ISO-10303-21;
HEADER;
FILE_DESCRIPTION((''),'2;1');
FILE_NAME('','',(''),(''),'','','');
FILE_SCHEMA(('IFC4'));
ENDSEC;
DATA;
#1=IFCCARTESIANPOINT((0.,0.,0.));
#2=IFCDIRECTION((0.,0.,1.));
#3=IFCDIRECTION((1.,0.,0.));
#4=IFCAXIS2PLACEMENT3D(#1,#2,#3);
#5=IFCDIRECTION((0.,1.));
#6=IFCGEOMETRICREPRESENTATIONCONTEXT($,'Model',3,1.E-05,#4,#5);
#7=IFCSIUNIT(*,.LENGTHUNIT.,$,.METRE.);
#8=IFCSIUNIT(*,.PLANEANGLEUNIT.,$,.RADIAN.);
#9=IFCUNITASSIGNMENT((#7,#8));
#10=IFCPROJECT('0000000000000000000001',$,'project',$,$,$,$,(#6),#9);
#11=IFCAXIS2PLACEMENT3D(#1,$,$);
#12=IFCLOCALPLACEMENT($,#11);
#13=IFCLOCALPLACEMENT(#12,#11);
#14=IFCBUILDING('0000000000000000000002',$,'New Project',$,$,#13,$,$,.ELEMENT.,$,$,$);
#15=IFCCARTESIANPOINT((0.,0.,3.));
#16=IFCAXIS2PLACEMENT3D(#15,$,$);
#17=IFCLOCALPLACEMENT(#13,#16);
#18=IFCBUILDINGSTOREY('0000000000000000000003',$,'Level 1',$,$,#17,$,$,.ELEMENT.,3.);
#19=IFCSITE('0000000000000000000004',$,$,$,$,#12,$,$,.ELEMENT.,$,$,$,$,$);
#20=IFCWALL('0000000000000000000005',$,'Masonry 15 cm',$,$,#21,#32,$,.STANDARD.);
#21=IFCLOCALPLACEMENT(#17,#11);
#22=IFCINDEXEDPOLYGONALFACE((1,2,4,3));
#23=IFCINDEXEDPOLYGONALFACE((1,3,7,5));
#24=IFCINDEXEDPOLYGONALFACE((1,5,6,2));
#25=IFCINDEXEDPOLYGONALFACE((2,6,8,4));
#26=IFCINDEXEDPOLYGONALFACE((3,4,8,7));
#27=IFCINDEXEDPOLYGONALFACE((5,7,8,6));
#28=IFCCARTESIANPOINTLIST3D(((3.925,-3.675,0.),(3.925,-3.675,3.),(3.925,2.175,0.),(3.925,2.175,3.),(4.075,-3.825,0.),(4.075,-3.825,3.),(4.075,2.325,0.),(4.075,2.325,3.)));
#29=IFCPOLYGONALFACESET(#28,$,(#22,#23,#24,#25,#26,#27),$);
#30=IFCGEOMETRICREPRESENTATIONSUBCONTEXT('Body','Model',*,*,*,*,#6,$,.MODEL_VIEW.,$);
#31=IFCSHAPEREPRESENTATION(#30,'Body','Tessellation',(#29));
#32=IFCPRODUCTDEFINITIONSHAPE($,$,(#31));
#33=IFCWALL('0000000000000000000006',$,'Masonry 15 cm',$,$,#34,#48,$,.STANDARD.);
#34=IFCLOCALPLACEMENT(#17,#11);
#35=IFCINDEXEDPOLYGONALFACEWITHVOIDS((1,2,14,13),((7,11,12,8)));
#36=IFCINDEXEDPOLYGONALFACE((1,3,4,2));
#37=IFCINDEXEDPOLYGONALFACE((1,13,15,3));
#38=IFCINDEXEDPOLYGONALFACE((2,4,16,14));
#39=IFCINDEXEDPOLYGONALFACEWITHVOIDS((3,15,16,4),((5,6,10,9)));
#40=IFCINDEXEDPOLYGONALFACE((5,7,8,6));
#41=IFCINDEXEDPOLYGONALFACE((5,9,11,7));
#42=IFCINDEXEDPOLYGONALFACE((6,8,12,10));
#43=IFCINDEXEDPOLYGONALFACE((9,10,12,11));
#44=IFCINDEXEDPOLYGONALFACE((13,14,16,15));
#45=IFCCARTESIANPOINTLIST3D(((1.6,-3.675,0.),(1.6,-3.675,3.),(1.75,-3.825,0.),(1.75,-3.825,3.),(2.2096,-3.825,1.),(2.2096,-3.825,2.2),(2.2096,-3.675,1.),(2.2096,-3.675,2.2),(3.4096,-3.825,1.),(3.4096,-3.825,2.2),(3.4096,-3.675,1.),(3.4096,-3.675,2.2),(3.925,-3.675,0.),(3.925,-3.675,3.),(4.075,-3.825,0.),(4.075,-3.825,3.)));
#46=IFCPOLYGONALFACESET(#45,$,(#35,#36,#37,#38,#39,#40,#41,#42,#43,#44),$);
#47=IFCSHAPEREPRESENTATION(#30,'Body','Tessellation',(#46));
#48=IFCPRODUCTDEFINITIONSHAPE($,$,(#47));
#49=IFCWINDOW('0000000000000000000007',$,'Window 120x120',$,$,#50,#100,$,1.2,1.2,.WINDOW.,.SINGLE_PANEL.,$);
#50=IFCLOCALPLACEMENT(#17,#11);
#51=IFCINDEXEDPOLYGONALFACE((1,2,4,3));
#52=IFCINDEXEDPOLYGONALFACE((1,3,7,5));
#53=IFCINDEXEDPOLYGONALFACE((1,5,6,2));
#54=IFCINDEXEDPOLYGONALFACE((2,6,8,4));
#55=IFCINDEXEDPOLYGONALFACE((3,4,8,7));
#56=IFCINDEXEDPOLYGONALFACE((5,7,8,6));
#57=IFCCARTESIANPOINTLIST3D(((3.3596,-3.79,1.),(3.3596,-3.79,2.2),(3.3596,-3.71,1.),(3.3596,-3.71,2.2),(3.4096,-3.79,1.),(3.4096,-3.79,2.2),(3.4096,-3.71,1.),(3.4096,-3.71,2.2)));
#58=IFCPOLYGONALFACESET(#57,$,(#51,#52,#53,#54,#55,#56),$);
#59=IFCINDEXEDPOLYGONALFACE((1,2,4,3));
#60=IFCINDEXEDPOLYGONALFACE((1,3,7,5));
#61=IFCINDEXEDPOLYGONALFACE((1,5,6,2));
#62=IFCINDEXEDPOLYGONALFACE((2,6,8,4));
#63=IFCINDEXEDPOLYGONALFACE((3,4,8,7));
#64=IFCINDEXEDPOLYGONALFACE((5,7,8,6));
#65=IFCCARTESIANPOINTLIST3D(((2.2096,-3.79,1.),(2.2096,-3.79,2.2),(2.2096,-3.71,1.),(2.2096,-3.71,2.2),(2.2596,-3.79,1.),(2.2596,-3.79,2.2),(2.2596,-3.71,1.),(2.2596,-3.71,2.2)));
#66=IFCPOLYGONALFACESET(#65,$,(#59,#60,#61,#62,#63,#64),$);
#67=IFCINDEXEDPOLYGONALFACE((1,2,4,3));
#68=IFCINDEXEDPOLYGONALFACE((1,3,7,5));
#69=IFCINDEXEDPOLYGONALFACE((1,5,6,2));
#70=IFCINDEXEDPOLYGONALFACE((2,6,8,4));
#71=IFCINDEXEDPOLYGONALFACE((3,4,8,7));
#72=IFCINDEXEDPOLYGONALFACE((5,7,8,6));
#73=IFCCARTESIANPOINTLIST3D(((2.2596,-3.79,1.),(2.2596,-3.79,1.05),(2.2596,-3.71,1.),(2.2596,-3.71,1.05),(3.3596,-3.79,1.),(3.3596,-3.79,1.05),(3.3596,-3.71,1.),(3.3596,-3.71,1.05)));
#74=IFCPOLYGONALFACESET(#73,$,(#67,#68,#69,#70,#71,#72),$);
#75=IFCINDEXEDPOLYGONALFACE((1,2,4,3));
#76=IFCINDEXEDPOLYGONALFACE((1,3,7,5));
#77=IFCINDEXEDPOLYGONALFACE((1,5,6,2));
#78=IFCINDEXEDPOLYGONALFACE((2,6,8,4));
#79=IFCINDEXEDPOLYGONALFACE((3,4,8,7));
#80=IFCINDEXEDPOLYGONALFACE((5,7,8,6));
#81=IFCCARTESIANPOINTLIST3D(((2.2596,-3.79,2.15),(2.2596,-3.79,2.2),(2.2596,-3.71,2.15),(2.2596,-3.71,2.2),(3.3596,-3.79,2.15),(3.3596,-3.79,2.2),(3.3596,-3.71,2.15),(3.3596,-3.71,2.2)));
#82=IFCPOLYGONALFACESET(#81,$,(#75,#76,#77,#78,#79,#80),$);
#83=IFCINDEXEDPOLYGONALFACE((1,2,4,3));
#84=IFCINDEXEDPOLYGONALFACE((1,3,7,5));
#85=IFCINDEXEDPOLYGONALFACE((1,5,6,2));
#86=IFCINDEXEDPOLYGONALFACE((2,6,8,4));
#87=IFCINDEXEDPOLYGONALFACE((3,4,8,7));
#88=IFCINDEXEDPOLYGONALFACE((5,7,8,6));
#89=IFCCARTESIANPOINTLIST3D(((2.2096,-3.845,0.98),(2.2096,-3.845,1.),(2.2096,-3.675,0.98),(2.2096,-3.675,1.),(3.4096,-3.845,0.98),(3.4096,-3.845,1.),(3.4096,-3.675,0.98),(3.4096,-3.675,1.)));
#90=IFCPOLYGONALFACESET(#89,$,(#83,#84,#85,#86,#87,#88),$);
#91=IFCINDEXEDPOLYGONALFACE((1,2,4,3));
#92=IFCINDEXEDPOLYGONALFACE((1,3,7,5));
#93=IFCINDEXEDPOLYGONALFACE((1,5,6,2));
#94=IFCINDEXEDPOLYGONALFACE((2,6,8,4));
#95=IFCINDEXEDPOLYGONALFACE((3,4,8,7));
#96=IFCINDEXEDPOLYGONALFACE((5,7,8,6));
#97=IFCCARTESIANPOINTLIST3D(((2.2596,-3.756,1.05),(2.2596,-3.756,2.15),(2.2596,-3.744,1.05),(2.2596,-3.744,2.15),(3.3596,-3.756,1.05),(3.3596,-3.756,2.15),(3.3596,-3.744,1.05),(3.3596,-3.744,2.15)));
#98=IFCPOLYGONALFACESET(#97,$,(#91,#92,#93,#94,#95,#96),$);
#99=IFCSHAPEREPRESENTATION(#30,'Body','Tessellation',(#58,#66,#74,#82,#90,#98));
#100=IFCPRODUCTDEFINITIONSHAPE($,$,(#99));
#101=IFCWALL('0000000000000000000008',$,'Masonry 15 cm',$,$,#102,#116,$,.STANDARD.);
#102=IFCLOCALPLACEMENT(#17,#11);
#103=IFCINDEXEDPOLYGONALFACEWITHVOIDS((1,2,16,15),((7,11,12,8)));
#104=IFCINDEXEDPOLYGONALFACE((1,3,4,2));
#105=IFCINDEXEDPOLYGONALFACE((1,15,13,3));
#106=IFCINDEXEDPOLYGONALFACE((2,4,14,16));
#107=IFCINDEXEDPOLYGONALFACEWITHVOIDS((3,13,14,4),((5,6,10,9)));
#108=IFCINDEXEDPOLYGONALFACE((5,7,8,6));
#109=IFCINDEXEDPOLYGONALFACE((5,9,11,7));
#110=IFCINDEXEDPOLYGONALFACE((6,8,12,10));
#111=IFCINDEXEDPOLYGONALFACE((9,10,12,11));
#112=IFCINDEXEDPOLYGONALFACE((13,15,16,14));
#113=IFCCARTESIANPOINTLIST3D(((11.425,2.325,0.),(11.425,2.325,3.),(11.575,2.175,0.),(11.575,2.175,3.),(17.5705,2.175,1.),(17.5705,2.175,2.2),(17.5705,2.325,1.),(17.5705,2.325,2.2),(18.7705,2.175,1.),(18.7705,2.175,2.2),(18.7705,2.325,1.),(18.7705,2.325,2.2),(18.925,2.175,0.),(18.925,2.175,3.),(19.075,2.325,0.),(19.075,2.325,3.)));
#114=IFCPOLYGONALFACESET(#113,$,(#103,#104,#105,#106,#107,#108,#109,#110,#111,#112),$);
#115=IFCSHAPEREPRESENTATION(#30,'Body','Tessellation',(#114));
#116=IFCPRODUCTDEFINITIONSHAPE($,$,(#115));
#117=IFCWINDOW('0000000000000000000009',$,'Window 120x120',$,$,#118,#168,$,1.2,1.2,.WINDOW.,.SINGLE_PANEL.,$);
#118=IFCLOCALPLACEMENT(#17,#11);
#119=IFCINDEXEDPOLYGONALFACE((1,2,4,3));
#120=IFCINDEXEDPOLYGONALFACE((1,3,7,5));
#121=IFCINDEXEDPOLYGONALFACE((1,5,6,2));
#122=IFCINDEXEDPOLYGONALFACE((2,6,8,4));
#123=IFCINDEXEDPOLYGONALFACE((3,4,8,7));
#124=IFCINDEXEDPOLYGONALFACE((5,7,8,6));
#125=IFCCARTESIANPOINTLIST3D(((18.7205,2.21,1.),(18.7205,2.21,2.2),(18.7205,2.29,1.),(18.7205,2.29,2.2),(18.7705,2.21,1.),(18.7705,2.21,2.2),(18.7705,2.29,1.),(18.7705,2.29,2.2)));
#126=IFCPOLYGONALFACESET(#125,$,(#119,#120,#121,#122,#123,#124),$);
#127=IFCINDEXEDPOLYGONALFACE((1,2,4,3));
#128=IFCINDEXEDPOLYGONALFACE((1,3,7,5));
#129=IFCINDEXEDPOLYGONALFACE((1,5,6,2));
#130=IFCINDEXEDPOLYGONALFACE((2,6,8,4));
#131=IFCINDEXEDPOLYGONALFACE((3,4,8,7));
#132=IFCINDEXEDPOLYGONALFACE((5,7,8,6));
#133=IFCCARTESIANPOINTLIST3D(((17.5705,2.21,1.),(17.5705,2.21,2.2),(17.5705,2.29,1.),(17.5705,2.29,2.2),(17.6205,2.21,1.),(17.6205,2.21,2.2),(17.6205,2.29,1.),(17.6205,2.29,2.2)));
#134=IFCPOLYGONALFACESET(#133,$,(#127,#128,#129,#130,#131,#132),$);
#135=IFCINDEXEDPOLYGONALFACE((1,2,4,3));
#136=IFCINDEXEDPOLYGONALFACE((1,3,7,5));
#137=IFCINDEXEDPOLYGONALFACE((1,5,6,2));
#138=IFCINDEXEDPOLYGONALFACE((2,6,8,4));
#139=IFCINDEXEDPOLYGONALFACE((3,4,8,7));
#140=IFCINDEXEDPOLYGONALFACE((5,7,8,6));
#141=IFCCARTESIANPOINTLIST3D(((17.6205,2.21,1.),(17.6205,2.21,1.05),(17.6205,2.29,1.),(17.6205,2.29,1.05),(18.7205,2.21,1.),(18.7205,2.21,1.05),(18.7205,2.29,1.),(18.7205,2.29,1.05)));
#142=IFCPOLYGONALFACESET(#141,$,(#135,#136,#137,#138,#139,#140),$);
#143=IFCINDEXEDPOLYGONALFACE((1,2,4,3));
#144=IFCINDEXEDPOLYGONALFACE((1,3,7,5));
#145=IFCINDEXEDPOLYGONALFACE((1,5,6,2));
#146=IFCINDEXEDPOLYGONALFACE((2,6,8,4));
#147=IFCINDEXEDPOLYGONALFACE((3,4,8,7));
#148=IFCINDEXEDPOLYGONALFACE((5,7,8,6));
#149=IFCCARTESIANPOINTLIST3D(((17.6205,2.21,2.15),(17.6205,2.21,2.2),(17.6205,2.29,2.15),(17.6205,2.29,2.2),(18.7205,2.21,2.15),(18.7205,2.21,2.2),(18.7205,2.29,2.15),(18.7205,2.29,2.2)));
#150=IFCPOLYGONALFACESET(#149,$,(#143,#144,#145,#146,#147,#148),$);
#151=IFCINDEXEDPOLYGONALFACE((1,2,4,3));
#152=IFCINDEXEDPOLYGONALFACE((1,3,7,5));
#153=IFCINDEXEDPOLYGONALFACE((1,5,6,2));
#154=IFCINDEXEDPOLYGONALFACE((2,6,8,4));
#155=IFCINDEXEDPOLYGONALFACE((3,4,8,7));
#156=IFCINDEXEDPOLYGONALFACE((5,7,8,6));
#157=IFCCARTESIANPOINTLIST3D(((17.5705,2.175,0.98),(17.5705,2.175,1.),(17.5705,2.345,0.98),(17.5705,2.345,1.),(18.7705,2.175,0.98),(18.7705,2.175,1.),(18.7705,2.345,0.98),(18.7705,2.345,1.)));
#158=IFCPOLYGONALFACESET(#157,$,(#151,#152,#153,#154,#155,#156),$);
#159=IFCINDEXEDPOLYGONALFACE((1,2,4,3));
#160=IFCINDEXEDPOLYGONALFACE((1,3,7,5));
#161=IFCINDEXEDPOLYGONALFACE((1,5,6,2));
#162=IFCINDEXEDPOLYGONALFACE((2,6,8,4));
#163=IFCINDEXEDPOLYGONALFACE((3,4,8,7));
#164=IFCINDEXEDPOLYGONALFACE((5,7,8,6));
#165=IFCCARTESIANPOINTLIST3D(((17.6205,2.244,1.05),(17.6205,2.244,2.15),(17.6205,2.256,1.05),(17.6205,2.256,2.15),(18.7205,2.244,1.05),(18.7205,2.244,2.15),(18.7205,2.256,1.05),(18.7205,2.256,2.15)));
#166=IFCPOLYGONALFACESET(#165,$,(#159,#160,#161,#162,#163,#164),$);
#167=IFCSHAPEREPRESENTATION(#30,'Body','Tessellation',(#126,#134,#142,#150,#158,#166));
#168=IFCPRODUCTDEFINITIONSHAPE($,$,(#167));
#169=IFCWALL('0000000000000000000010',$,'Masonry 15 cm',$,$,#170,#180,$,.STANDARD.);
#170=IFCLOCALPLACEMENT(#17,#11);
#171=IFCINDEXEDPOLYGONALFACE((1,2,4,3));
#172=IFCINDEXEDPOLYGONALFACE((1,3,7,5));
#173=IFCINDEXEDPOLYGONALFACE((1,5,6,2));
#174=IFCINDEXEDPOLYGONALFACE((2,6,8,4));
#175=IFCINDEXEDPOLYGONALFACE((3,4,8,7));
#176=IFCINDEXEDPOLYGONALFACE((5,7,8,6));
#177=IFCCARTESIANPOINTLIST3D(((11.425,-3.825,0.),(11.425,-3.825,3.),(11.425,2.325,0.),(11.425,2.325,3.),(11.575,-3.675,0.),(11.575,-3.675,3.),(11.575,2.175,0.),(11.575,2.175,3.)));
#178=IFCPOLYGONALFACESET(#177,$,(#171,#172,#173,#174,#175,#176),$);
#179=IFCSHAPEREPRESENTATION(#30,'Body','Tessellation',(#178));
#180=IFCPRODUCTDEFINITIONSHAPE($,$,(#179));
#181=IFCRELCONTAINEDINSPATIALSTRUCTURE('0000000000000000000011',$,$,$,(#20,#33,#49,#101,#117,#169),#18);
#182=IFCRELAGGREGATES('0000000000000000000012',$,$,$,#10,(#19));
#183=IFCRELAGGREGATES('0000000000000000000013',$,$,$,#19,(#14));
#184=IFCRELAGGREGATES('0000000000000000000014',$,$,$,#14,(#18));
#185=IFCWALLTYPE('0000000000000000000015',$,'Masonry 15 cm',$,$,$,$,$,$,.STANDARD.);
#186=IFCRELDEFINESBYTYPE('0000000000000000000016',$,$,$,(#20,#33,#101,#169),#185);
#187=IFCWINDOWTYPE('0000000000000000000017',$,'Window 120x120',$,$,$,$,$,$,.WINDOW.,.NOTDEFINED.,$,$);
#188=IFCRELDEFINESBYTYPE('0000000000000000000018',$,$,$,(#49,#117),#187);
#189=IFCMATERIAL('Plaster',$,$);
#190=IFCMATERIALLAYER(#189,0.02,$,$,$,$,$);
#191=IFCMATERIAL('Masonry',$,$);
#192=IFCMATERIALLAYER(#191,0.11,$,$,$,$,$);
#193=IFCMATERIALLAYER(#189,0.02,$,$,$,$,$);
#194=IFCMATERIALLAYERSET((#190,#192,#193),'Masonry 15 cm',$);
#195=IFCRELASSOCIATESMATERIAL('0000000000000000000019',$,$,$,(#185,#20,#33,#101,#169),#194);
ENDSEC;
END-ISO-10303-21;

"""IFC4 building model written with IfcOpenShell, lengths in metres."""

from ifc_helpers import new_model, si_unit, direction, frame, frame_2d, origin, origin_with_axes, place, context, subcontext, project, spatial, polyline, rectangle, outline, extrude, material, layer, layer_set, layer_usage, type_object, element, fill, save


model = new_model("IFC4")

# Units and contexts
model_context = context("Model", 3, precision=1e-05, world=origin_with_axes(), true_north=direction((0.0, 1.0)))
body_context = subcontext(model_context, "Body", "Model", "MODEL_VIEW")
ifc_project = project(units=[si_unit("LENGTHUNIT", "METRE"), si_unit("PLANEANGLEUNIT", "RADIAN")], contexts=[model_context])

# Site, building, storey
site_placement = place(None, origin())
site = spatial("IfcSite", under=ifc_project, at=site_placement, CompositionType="ELEMENT")
building_placement = place(site_placement, origin())
building = spatial("IfcBuilding", under=site, at=building_placement, Name="New Project", CompositionType="ELEMENT")
storey_placement = place(building_placement, frame((0.0, 0.0, 3.0)))
storey = spatial("IfcBuildingStorey", under=building, at=storey_placement, Name="Level 1", CompositionType="ELEMENT", Elevation=3.0)

# Wall
ifc_material_1 = material(Name="Plaster")
ifc_layer_1 = layer(ifc_material_1, 0.02)
ifc_material_2 = material(Name="Masonry")
ifc_layer_2 = layer(ifc_material_2, 0.11)
ifc_layer_3 = layer(ifc_material_1, 0.02)
ifc_layer_set_1 = layer_set([ifc_layer_1, ifc_layer_2, ifc_layer_3], Name="Masonry 15 cm")
ifc_layer_usage_1 = layer_usage(ifc_layer_set_1, "AXIS2", "NEGATIVE", 0.075)
wall_type_1 = type_object("IfcWallType", Name="Masonry 15 cm", PredefinedType="STANDARD", material=ifc_layer_set_1)
wall_1_placement = place(storey_placement, frame((4.0, 2.25, 0.0), z_axis=(0.0, 0.0, 1.0), x_axis=(0.0, -1.0, 0.0)))
element("IfcWall", 1, at=wall_1_placement, inside=storey, type_object=wall_type_1, material=ifc_layer_usage_1, Name="Masonry 15 cm", PredefinedType="STANDARD", context=body_context, shape_type="SweptSolid", body=[
    extrude(outline(polyline([(0.075, -0.075), (5.925, -0.075), (6.075, 0.075), (-0.075, 0.075), (0.075, -0.075)])), origin(), (0.0, 0.0, 1.0), 3.0),
])

# Walls, openings, windows
wall_2_placement = place(storey_placement, frame((4.0, -3.75, 0.0), z_axis=(0.0, 0.0, 1.0), x_axis=(-1.0, 0.0, 0.0)))
wall_2 = element("IfcWall", 2, at=wall_2_placement, inside=storey, type_object=wall_type_1, material=ifc_layer_usage_1, Name="Masonry 15 cm", PredefinedType="STANDARD", context=body_context, shape_type="SweptSolid", body=[
    extrude(outline(polyline([(0.075, -0.075), (2.4, -0.075), (2.25, 0.075), (-0.075, 0.075), (0.075, -0.075)])), origin(), (0.0, 0.0, 1.0), 3.0),
])
opening_1_placement = place(wall_2_placement, frame((0.5904, 0.0, 1.0)))
opening_1 = element("IfcOpeningElement", 3, at=opening_1_placement, cuts=wall_2, PredefinedType="OPENING", context=body_context, shape_type="SweptSolid", body=[
    extrude(rectangle(XDim=1.2, YDim=0.25, at=frame_2d((0.6, 0.0))), origin(), (0.0, 0.0, 1.0), 1.2),
])
window_type_1 = type_object("IfcWindowType", Name="Window 120x120", PartitioningType="NOTDEFINED", PredefinedType="WINDOW")
window_1_placement = place(opening_1_placement, origin())
window_1 = element("IfcWindow", 4, at=window_1_placement, inside=storey, type_object=window_type_1, Name="Window 120x120", OverallHeight=1.2, OverallWidth=1.2, PartitioningType="SINGLE_PANEL", PredefinedType="WINDOW", context=body_context, shape_type="SweptSolid", body=[
    extrude(outline(polyline([(0.0, -0.04), (0.05, -0.04), (0.05, 0.04), (0.0, 0.04), (0.0, -0.04)])), origin(), (0.0, 0.0, 1.0), 1.2),
    extrude(outline(polyline([(1.15, -0.04), (1.2, -0.04), (1.2, 0.04), (1.15, 0.04), (1.15, -0.04)])), origin(), (0.0, 0.0, 1.0), 1.2),
    extrude(outline(polyline([(0.05, -0.04), (1.15, -0.04), (1.15, 0.04), (0.05, 0.04), (0.05, -0.04)])), origin(), (0.0, 0.0, 1.0), 0.05),
    extrude(outline(polyline([(0.05, -0.04), (1.15, -0.04), (1.15, 0.04), (0.05, 0.04), (0.05, -0.04)])), frame((0.0, 0.0, 1.15)), (0.0, 0.0, 1.0), 0.05),
    extrude(outline(polyline([(0.0, -0.075), (1.2, -0.075), (1.2, 0.095), (0.0, 0.095), (0.0, -0.075)])), frame((0.0, 0.0, -0.02)), (0.0, 0.0, 1.0), 0.02),
    extrude(outline(polyline([(0.05, -0.006), (1.15, -0.006), (1.15, 0.006), (0.05, 0.006), (0.05, -0.006)])), frame((0.0, 0.0, 0.05)), (0.0, 0.0, 1.0), 1.1),
])
fill(opening_1, window_1)
wall_3_placement = place(storey_placement, frame((11.5, 2.25, 0.0), z_axis=(0.0, 0.0, 1.0), x_axis=(1.0, 0.0, 0.0)))
wall_3 = element("IfcWall", 5, at=wall_3_placement, inside=storey, type_object=wall_type_1, material=ifc_layer_usage_1, Name="Masonry 15 cm", PredefinedType="STANDARD", context=body_context, shape_type="SweptSolid", body=[
    extrude(outline(polyline([(0.075, -0.075), (7.425, -0.075), (7.575, 0.075), (-0.075, 0.075), (0.075, -0.075)])), origin(), (0.0, 0.0, 1.0), 3.0),
])
opening_2_placement = place(wall_3_placement, frame((6.0705, 0.0, 1.0)))
opening_2 = element("IfcOpeningElement", 6, at=opening_2_placement, cuts=wall_3, PredefinedType="OPENING", context=body_context, shape_type="SweptSolid", body=[
    extrude(rectangle(XDim=1.2, YDim=0.25, at=frame_2d((0.6, 0.0))), origin(), (0.0, 0.0, 1.0), 1.2),
])
window_2_placement = place(opening_2_placement, origin())
window_2 = element("IfcWindow", 7, at=window_2_placement, inside=storey, type_object=window_type_1, Name="Window 120x120", OverallHeight=1.2, OverallWidth=1.2, PartitioningType="SINGLE_PANEL", PredefinedType="WINDOW", context=body_context, shape_type="SweptSolid", body=[
    extrude(outline(polyline([(1.2, 0.04), (1.15, 0.04), (1.15, -0.04), (1.2, -0.04), (1.2, 0.04)])), origin(), (0.0, 0.0, 1.0), 1.2),
    extrude(outline(polyline([(0.05, 0.04), (0.0, 0.04), (0.0, -0.04), (0.05, -0.04), (0.05, 0.04)])), origin(), (0.0, 0.0, 1.0), 1.2),
    extrude(outline(polyline([(1.15, 0.04), (0.05, 0.04), (0.05, -0.04), (1.15, -0.04), (1.15, 0.04)])), origin(), (0.0, 0.0, 1.0), 0.05),
    extrude(outline(polyline([(1.15, 0.04), (0.05, 0.04), (0.05, -0.04), (1.15, -0.04), (1.15, 0.04)])), frame((0.0, 0.0, 1.15)), (0.0, 0.0, 1.0), 0.05),
    extrude(outline(polyline([(1.2, 0.095), (0.0, 0.095), (0.0, -0.075), (1.2, -0.075), (1.2, 0.095)])), frame((0.0, 0.0, -0.02)), (0.0, 0.0, 1.0), 0.02),
    extrude(outline(polyline([(1.15, 0.006), (0.05, 0.006), (0.05, -0.006), (1.15, -0.006), (1.15, 0.006)])), frame((0.0, 0.0, 0.05)), (0.0, 0.0, 1.0), 1.1),
])
fill(opening_2, window_2)

# Wall
wall_4_placement = place(storey_placement, frame((11.5, -3.75, 0.0), z_axis=(0.0, 0.0, 1.0), x_axis=(0.0, 1.0, 0.0)))
element("IfcWall", 8, at=wall_4_placement, inside=storey, type_object=wall_type_1, material=ifc_layer_usage_1, Name="Masonry 15 cm", PredefinedType="STANDARD", context=body_context, shape_type="SweptSolid", body=[
    extrude(outline(polyline([(0.075, -0.075), (5.925, -0.075), (6.075, 0.075), (-0.075, 0.075), (0.075, -0.075)])), origin(), (0.0, 0.0, 1.0), 3.0),
])

save(model, "model.ifc")
